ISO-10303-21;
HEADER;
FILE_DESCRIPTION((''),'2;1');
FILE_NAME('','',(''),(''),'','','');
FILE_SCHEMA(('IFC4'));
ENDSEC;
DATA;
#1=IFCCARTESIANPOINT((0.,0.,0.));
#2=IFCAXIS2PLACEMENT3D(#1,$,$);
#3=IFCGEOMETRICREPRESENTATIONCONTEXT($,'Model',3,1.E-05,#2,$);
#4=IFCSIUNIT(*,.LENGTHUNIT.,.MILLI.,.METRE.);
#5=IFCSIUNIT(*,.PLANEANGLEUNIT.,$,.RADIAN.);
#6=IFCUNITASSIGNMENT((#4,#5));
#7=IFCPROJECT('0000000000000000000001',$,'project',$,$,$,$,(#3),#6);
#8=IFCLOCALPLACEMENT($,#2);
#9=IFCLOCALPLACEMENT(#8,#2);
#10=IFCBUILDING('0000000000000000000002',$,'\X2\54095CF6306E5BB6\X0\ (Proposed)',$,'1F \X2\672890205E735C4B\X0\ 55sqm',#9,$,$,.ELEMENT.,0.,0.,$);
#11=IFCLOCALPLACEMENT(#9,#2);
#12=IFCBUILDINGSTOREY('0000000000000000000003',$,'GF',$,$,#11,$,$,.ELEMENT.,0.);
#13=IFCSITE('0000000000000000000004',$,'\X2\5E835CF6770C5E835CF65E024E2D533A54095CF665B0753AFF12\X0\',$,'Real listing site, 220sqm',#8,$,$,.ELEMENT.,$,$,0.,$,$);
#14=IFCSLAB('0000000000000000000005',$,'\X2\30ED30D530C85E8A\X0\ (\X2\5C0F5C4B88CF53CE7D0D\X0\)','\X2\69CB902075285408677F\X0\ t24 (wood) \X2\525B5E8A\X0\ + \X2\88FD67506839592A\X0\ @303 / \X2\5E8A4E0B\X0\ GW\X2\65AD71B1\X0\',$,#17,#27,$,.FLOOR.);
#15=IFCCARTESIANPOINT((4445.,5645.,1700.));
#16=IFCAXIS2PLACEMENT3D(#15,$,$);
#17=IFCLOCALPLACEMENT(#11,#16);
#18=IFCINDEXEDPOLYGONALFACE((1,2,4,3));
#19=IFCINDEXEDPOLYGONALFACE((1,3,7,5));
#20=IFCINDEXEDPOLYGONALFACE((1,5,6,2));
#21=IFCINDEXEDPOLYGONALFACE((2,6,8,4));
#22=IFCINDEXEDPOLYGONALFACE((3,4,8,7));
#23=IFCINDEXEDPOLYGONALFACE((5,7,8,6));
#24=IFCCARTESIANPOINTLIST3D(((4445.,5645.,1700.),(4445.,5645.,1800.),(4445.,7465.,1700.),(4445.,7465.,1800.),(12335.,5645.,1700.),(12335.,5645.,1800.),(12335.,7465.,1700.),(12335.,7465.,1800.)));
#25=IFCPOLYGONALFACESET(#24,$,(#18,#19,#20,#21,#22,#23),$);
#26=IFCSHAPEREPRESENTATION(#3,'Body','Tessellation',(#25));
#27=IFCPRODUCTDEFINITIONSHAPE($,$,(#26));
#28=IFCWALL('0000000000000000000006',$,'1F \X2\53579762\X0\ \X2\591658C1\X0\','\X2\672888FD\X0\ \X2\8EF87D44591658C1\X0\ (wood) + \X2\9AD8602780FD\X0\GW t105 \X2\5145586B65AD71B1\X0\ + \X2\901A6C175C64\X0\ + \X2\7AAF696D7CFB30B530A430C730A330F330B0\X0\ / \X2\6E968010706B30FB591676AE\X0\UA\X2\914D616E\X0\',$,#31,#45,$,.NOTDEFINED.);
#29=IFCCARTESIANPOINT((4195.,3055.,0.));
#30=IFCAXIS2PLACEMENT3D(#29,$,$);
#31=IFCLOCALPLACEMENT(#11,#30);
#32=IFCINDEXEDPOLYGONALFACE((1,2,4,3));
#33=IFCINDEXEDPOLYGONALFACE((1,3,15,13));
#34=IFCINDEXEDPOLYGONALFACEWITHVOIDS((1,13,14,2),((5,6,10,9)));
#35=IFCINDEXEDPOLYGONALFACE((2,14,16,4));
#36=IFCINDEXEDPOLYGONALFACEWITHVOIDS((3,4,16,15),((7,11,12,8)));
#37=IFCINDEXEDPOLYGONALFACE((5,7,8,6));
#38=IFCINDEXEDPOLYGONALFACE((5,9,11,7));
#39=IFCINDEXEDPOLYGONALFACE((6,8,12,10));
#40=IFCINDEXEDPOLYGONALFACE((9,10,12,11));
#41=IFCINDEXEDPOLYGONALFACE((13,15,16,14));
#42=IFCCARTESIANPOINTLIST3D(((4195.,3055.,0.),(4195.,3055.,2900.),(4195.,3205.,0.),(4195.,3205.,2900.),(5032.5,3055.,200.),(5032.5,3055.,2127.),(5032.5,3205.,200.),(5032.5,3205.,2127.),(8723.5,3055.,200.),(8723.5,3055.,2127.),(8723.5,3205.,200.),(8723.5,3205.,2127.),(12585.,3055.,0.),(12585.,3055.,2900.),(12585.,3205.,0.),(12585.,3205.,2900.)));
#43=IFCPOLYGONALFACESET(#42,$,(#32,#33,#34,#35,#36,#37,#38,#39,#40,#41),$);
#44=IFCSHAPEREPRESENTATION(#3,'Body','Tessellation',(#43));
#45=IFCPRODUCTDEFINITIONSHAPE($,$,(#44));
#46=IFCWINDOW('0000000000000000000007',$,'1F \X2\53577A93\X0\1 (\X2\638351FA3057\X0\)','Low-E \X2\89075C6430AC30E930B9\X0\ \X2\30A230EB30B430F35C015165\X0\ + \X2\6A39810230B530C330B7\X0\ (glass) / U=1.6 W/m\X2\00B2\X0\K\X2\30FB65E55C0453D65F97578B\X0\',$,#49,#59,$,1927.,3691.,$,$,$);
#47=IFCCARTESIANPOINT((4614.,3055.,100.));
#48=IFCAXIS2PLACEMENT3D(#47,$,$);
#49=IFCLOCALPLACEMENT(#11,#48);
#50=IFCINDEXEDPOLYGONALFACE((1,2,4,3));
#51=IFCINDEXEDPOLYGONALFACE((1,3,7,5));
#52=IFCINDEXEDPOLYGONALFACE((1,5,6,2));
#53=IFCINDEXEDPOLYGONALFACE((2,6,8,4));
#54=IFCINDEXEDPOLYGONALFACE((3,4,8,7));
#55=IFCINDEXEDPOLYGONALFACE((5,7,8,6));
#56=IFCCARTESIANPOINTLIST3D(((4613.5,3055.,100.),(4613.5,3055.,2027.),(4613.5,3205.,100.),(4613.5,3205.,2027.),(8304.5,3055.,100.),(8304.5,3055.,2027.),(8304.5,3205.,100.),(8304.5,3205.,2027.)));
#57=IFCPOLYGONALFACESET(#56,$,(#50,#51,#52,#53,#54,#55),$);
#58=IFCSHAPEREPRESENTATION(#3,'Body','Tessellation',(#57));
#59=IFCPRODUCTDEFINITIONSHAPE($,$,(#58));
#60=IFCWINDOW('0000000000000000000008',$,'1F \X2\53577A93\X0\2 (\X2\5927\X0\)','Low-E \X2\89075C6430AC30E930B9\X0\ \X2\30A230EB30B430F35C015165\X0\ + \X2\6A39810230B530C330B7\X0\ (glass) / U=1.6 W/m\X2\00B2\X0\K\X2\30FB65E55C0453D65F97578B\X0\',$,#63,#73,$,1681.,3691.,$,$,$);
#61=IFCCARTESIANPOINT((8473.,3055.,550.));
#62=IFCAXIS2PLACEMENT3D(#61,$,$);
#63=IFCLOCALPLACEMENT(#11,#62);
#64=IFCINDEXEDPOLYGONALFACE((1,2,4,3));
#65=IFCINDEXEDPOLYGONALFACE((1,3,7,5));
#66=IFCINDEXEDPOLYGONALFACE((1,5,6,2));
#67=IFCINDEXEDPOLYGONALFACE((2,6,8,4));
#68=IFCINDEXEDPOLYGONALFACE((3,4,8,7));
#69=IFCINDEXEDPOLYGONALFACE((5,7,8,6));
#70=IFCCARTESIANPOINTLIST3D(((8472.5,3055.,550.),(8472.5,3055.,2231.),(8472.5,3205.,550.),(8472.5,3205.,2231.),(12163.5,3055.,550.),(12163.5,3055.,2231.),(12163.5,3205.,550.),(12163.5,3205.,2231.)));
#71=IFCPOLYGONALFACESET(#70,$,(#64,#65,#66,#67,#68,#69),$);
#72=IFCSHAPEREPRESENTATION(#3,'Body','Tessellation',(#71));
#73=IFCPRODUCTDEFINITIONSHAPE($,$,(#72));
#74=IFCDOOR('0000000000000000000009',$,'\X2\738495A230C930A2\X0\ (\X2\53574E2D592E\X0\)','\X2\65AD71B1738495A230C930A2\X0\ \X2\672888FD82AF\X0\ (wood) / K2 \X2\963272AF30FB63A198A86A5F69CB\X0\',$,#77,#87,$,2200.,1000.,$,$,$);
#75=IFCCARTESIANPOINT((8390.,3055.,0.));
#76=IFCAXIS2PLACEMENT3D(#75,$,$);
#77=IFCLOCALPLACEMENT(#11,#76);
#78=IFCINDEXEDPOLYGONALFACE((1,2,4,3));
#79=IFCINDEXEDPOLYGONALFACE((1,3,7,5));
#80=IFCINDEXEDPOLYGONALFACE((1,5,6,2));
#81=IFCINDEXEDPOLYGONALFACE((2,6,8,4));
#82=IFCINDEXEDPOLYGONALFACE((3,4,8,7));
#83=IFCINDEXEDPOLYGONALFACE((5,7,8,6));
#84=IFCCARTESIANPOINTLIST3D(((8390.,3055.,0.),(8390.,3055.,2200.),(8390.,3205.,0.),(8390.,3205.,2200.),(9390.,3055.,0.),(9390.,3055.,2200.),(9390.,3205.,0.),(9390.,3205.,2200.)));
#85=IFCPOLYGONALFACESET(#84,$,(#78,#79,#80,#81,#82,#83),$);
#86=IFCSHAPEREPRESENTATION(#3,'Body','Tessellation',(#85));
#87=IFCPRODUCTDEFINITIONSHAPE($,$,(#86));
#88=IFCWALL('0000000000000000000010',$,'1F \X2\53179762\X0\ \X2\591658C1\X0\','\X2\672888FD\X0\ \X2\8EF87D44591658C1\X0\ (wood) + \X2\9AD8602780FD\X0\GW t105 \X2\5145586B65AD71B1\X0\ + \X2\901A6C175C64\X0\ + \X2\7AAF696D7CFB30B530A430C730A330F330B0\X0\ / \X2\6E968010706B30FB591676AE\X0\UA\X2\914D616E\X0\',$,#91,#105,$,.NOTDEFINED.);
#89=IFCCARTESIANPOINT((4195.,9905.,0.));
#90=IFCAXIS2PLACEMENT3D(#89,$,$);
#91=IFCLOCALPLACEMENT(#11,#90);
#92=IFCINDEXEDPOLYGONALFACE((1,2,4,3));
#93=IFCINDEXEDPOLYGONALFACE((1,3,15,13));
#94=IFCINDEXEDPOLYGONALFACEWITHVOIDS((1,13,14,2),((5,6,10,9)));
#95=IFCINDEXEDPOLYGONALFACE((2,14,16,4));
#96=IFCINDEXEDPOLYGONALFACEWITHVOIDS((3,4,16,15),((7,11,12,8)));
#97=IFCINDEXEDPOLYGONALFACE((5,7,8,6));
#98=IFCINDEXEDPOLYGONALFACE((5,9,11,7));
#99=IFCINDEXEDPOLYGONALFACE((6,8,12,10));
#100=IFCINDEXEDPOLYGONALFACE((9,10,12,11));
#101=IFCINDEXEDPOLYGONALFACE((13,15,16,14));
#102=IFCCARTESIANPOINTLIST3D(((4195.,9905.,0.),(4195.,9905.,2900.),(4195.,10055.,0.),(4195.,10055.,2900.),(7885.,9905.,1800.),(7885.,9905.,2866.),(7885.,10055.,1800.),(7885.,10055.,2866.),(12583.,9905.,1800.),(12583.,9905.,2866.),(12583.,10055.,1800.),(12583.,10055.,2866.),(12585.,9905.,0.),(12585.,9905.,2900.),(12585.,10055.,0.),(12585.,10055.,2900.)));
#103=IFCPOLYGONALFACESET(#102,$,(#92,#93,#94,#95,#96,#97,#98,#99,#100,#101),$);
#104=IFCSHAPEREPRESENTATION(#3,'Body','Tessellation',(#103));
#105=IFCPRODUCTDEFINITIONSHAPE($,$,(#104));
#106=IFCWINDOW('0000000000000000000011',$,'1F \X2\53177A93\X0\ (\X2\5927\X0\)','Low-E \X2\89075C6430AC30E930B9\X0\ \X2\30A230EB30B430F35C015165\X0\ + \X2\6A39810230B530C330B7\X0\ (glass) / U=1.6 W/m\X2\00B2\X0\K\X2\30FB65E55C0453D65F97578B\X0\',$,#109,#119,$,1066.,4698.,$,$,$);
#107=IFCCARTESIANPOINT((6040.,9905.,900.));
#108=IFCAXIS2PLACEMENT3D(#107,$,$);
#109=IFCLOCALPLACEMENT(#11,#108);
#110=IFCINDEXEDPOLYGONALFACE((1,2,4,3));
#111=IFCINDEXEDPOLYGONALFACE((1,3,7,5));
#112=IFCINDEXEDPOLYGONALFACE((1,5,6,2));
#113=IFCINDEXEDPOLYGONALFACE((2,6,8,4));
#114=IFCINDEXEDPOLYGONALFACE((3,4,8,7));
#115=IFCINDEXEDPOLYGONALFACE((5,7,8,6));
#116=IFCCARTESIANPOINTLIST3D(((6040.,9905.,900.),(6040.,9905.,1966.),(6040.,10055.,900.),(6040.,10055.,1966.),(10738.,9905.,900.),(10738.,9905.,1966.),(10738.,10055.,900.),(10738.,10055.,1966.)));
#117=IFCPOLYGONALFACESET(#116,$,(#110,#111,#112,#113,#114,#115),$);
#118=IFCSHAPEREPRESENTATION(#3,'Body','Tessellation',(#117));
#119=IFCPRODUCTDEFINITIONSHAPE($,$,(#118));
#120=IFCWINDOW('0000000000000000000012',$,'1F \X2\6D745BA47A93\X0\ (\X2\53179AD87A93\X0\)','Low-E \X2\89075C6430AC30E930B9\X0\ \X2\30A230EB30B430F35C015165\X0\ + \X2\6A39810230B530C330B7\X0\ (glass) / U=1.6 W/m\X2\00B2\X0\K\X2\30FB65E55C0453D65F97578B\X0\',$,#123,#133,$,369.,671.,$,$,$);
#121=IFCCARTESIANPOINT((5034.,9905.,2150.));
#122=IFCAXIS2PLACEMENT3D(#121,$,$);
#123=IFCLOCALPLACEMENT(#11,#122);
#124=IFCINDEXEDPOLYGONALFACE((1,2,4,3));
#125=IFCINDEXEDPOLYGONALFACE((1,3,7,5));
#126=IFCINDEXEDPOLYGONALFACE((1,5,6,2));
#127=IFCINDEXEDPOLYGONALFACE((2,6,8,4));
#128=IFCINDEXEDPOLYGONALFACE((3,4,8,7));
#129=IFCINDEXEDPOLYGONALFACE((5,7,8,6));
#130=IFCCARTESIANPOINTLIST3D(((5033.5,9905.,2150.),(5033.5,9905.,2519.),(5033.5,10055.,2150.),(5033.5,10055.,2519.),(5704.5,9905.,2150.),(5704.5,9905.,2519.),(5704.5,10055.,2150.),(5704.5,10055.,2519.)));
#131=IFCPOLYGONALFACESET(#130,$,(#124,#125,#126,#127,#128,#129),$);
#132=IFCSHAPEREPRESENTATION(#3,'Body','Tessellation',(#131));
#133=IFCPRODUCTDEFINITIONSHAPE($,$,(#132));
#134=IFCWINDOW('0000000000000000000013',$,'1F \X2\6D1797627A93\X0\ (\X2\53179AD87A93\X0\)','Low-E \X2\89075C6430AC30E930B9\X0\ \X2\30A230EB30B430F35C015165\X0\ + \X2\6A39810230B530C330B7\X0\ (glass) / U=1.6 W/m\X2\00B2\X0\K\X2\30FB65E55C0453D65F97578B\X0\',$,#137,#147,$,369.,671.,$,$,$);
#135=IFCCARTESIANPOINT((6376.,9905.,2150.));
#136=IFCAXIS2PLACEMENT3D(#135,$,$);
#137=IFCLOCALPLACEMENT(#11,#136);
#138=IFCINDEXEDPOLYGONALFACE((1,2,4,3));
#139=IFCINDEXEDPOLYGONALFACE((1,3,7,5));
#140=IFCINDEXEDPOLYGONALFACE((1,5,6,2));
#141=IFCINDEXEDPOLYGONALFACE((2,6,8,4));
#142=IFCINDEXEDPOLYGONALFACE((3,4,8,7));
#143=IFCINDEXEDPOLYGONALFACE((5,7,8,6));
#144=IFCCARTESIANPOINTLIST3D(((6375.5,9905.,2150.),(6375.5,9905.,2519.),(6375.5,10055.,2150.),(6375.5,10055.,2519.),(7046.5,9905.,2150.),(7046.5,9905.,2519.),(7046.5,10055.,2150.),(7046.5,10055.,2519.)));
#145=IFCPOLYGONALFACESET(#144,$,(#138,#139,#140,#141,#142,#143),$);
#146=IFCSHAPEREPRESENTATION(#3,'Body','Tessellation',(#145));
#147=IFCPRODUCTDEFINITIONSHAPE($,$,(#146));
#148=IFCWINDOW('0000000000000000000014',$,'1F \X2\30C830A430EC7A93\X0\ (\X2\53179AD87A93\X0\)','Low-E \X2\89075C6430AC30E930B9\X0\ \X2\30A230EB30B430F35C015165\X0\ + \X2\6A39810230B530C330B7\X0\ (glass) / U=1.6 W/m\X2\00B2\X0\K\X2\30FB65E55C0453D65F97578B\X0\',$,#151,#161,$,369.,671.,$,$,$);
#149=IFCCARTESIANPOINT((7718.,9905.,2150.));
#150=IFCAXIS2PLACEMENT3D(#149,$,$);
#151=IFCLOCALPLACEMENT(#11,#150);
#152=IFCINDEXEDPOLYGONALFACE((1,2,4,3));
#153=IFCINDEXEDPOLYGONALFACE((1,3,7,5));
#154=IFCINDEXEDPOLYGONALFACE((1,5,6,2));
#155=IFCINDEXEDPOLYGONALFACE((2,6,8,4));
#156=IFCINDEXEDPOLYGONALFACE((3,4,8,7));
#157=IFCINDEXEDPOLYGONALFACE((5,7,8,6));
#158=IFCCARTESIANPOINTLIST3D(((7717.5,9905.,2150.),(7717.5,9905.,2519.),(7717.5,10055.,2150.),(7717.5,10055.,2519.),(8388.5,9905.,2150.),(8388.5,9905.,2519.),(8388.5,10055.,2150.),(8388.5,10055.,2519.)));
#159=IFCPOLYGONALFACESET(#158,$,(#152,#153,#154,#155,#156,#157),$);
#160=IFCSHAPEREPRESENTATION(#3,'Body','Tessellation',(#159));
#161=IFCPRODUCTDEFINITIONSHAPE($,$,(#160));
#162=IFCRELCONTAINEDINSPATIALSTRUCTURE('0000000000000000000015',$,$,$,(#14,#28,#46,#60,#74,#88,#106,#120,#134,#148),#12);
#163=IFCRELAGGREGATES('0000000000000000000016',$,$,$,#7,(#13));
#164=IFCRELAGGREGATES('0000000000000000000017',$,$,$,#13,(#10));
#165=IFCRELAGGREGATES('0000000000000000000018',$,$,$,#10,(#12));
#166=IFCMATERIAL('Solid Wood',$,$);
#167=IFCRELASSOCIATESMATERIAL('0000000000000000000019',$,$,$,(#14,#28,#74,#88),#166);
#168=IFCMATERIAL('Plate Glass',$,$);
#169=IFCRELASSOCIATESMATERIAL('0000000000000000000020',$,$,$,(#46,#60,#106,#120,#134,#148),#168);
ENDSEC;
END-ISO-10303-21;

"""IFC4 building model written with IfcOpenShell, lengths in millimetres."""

from ifc_helpers import new_model, si_unit, frame, frame_2d, origin, place, context, project, spatial, rectangle, extrude, material, element, fill, save


model = new_model("IFC4")

# Units and contexts
model_context = context("Model", 3, precision=1e-05, world=origin())
ifc_project = project(units=[si_unit("LENGTHUNIT", "METRE", prefix="MILLI"), si_unit("PLANEANGLEUNIT", "RADIAN")], contexts=[model_context])

# Site, building, storey
site_placement = place(None, origin())
site = spatial("IfcSite", under=ifc_project, at=site_placement, Name="広島県広島市中区吉島新町２", ObjectType="Real listing site, 220sqm", CompositionType="ELEMENT", RefElevation=0.0)
building_placement = place(site_placement, origin())
building = spatial("IfcBuilding", under=site, at=building_placement, Name="吉島の家 (Proposed)", ObjectType="1F 木造平屋 55sqm", CompositionType="ELEMENT", ElevationOfRefHeight=0.0, ElevationOfTerrain=0.0)
storey_placement = place(building_placement, origin())
storey = spatial("IfcBuildingStorey", under=building, at=storey_placement, Name="GF", CompositionType="ELEMENT", Elevation=0.0)

# Slab
ifc_material_1 = material(Name="Solid Wood")
slab_1_placement = place(storey_placement, frame((4445.0, 5645.0, 1700.0)))
element("IfcSlab", 1, at=slab_1_placement, inside=storey, material=ifc_material_1, Name="ロフト床 (小屋裏収納)", Description="構造用合板 t24 (wood) 剛床 + 製材根太 @303 / 床下 GW断熱", PredefinedType="FLOOR", context=model_context, shape_type="SweptSolid", body=[
    extrude(rectangle(XDim=7890.0, YDim=1820.0, at=frame_2d((3945.0, 910.0))), frame((4445.0, 5645.0, 1700.0)), (0.0, 0.0, 1.0), 100.0),
])

# Wall, openings, windows, door
wall_1_placement = place(storey_placement, frame((4195.0, 3055.0, 0.0)))
wall_1 = element("IfcWall", 2, at=wall_1_placement, inside=storey, material=ifc_material_1, Name="1F 南面 外壁", Description="木製 軸組外壁 (wood) + 高性能GW t105 充填断熱 + 通気層 + 窯業系サイディング / 準耐火・外皮UA配慮", PredefinedType="NOTDEFINED", context=model_context, shape_type="SweptSolid", body=[
    extrude(rectangle(XDim=8390.0, YDim=150.0, at=frame_2d((4195.0, 75.0))), frame((4195.0, 3055.0, 0.0)), (0.0, 0.0, 1.0), 2900.0),
])
opening_1_placement = place(storey_placement, frame((4614.0, 3055.0, 100.0)))
opening_1 = element("IfcOpeningElement", 3, at=opening_1_placement, cuts=wall_1, PredefinedType="NOTDEFINED", context=model_context, shape_type="SweptSolid", body=[
    extrude(rectangle(XDim=3691.0, YDim=150.0, at=frame_2d((1845.0, 75.0))), frame((4614.0, 3055.0, 100.0)), (0.0, 0.0, 1.0), 1927.0),
])
opening_2_placement = place(storey_placement, frame((8473.0, 3055.0, 550.0)))
opening_2 = element("IfcOpeningElement", 4, at=opening_2_placement, cuts=wall_1, PredefinedType="NOTDEFINED", context=model_context, shape_type="SweptSolid", body=[
    extrude(rectangle(XDim=3691.0, YDim=150.0, at=frame_2d((1845.0, 75.0))), frame((8473.0, 3055.0, 550.0)), (0.0, 0.0, 1.0), 1681.0),
])
opening_3_placement = place(storey_placement, frame((8390.0, 3055.0, 0.0)))
opening_3 = element("IfcOpeningElement", 5, at=opening_3_placement, cuts=wall_1, PredefinedType="NOTDEFINED", context=model_context, shape_type="SweptSolid", body=[
    extrude(rectangle(XDim=1000.0, YDim=150.0, at=frame_2d((500.0, 75.0))), frame((8390.0, 3055.0, 0.0)), (0.0, 0.0, 1.0), 2200.0),
])
ifc_material_2 = material(Name="Plate Glass")
window_1_placement = place(storey_placement, frame((4614.0, 3055.0, 100.0)))
window_1 = element("IfcWindow", 6, at=window_1_placement, inside=storey, material=ifc_material_2, Name="1F 南窓1 (掃出し)", Description="Low-E 複層ガラス アルゴン封入 + 樹脂サッシ (glass) / U=1.6 W/m²K・日射取得型", OverallHeight=1927.0, OverallWidth=3691.0, context=model_context, shape_type="SweptSolid", body=[
    extrude(rectangle(XDim=3691.0, YDim=150.0, at=frame_2d((1845.0, 75.0))), frame((4614.0, 3055.0, 100.0)), (0.0, 0.0, 1.0), 1927.0),
])
fill(opening_1, window_1)
window_2_placement = place(storey_placement, frame((8473.0, 3055.0, 550.0)))
window_2 = element("IfcWindow", 7, at=window_2_placement, inside=storey, material=ifc_material_2, Name="1F 南窓2 (大)", Description="Low-E 複層ガラス アルゴン封入 + 樹脂サッシ (glass) / U=1.6 W/m²K・日射取得型", OverallHeight=1681.0, OverallWidth=3691.0, context=model_context, shape_type="SweptSolid", body=[
    extrude(rectangle(XDim=3691.0, YDim=150.0, at=frame_2d((1845.0, 75.0))), frame((8473.0, 3055.0, 550.0)), (0.0, 0.0, 1.0), 1681.0),
])
fill(opening_2, window_2)
door_1_placement = place(storey_placement, frame((8390.0, 3055.0, 0.0)))
door_1 = element("IfcDoor", 8, at=door_1_placement, inside=storey, material=ifc_material_1, Name="玄関ドア (南中央)", Description="断熱玄関ドア 木製芯 (wood) / K2 防犯・採風機構", OverallHeight=2200.0, OverallWidth=1000.0, context=model_context, shape_type="SweptSolid", body=[
    extrude(rectangle(XDim=1000.0, YDim=150.0, at=frame_2d((500.0, 75.0))), frame((8390.0, 3055.0, 0.0)), (0.0, 0.0, 1.0), 2200.0),
])
fill(opening_3, door_1)

# Wall, openings, windows
wall_2_placement = place(storey_placement, frame((4195.0, 9905.0, 0.0)))
wall_2 = element("IfcWall", 9, at=wall_2_placement, inside=storey, material=ifc_material_1, Name="1F 北面 外壁", Description="木製 軸組外壁 (wood) + 高性能GW t105 充填断熱 + 通気層 + 窯業系サイディング / 準耐火・外皮UA配慮", PredefinedType="NOTDEFINED", context=model_context, shape_type="SweptSolid", body=[
    extrude(rectangle(XDim=8390.0, YDim=150.0, at=frame_2d((4195.0, 75.0))), frame((4195.0, 9905.0, 0.0)), (0.0, 0.0, 1.0), 2900.0),
])
opening_4_placement = place(storey_placement, frame((6040.0, 9905.0, 900.0)))
opening_4 = element("IfcOpeningElement", 10, at=opening_4_placement, cuts=wall_2, PredefinedType="NOTDEFINED", context=model_context, shape_type="SweptSolid", body=[
    extrude(rectangle(XDim=4698.0, YDim=150.0, at=frame_2d((2349.0, 75.0))), frame((6040.0, 9905.0, 900.0)), (0.0, 0.0, 1.0), 1066.0),
])
opening_5_placement = place(storey_placement, frame((5034.0, 9905.0, 2150.0)))
opening_5 = element("IfcOpeningElement", 11, at=opening_5_placement, cuts=wall_2, PredefinedType="NOTDEFINED", context=model_context, shape_type="SweptSolid", body=[
    extrude(rectangle(XDim=671.0, YDim=150.0, at=frame_2d((335.0, 75.0))), frame((5034.0, 9905.0, 2150.0)), (0.0, 0.0, 1.0), 369.0),
])
opening_6_placement = place(storey_placement, frame((6376.0, 9905.0, 2150.0)))
opening_6 = element("IfcOpeningElement", 12, at=opening_6_placement, cuts=wall_2, PredefinedType="NOTDEFINED", context=model_context, shape_type="SweptSolid", body=[
    extrude(rectangle(XDim=671.0, YDim=150.0, at=frame_2d((335.0, 75.0))), frame((6376.0, 9905.0, 2150.0)), (0.0, 0.0, 1.0), 369.0),
])
opening_7_placement = place(storey_placement, frame((7718.0, 9905.0, 2150.0)))
opening_7 = element("IfcOpeningElement", 13, at=opening_7_placement, cuts=wall_2, PredefinedType="NOTDEFINED", context=model_context, shape_type="SweptSolid", body=[
    extrude(rectangle(XDim=671.0, YDim=150.0, at=frame_2d((335.0, 75.0))), frame((7718.0, 9905.0, 2150.0)), (0.0, 0.0, 1.0), 369.0),
])
window_3_placement = place(storey_placement, frame((6040.0, 9905.0, 900.0)))
window_3 = element("IfcWindow", 14, at=window_3_placement, inside=storey, material=ifc_material_2, Name="1F 北窓 (大)", Description="Low-E 複層ガラス アルゴン封入 + 樹脂サッシ (glass) / U=1.6 W/m²K・日射取得型", OverallHeight=1066.0, OverallWidth=4698.0, context=model_context, shape_type="SweptSolid", body=[
    extrude(rectangle(XDim=4698.0, YDim=150.0, at=frame_2d((2349.0, 75.0))), frame((6040.0, 9905.0, 900.0)), (0.0, 0.0, 1.0), 1066.0),
])
fill(opening_4, window_3)
window_4_placement = place(storey_placement, frame((5034.0, 9905.0, 2150.0)))
window_4 = element("IfcWindow", 15, at=window_4_placement, inside=storey, material=ifc_material_2, Name="1F 浴室窓 (北高窓)", Description="Low-E 複層ガラス アルゴン封入 + 樹脂サッシ (glass) / U=1.6 W/m²K・日射取得型", OverallHeight=369.0, OverallWidth=671.0, context=model_context, shape_type="SweptSolid", body=[
    extrude(rectangle(XDim=671.0, YDim=150.0, at=frame_2d((335.0, 75.0))), frame((5034.0, 9905.0, 2150.0)), (0.0, 0.0, 1.0), 369.0),
])
fill(opening_5, window_4)
window_5_placement = place(storey_placement, frame((6376.0, 9905.0, 2150.0)))
window_5 = element("IfcWindow", 16, at=window_5_placement, inside=storey, material=ifc_material_2, Name="1F 洗面窓 (北高窓)", Description="Low-E 複層ガラス アルゴン封入 + 樹脂サッシ (glass) / U=1.6 W/m²K・日射取得型", OverallHeight=369.0, OverallWidth=671.0, context=model_context, shape_type="SweptSolid", body=[
    extrude(rectangle(XDim=671.0, YDim=150.0, at=frame_2d((335.0, 75.0))), frame((6376.0, 9905.0, 2150.0)), (0.0, 0.0, 1.0), 369.0),
])
fill(opening_6, window_5)
window_6_placement = place(storey_placement, frame((7718.0, 9905.0, 2150.0)))
window_6 = element("IfcWindow", 17, at=window_6_placement, inside=storey, material=ifc_material_2, Name="1F トイレ窓 (北高窓)", Description="Low-E 複層ガラス アルゴン封入 + 樹脂サッシ (glass) / U=1.6 W/m²K・日射取得型", OverallHeight=369.0, OverallWidth=671.0, context=model_context, shape_type="SweptSolid", body=[
    extrude(rectangle(XDim=671.0, YDim=150.0, at=frame_2d((335.0, 75.0))), frame((7718.0, 9905.0, 2150.0)), (0.0, 0.0, 1.0), 369.0),
])
fill(opening_7, window_6)

save(model, "model.ifc")
